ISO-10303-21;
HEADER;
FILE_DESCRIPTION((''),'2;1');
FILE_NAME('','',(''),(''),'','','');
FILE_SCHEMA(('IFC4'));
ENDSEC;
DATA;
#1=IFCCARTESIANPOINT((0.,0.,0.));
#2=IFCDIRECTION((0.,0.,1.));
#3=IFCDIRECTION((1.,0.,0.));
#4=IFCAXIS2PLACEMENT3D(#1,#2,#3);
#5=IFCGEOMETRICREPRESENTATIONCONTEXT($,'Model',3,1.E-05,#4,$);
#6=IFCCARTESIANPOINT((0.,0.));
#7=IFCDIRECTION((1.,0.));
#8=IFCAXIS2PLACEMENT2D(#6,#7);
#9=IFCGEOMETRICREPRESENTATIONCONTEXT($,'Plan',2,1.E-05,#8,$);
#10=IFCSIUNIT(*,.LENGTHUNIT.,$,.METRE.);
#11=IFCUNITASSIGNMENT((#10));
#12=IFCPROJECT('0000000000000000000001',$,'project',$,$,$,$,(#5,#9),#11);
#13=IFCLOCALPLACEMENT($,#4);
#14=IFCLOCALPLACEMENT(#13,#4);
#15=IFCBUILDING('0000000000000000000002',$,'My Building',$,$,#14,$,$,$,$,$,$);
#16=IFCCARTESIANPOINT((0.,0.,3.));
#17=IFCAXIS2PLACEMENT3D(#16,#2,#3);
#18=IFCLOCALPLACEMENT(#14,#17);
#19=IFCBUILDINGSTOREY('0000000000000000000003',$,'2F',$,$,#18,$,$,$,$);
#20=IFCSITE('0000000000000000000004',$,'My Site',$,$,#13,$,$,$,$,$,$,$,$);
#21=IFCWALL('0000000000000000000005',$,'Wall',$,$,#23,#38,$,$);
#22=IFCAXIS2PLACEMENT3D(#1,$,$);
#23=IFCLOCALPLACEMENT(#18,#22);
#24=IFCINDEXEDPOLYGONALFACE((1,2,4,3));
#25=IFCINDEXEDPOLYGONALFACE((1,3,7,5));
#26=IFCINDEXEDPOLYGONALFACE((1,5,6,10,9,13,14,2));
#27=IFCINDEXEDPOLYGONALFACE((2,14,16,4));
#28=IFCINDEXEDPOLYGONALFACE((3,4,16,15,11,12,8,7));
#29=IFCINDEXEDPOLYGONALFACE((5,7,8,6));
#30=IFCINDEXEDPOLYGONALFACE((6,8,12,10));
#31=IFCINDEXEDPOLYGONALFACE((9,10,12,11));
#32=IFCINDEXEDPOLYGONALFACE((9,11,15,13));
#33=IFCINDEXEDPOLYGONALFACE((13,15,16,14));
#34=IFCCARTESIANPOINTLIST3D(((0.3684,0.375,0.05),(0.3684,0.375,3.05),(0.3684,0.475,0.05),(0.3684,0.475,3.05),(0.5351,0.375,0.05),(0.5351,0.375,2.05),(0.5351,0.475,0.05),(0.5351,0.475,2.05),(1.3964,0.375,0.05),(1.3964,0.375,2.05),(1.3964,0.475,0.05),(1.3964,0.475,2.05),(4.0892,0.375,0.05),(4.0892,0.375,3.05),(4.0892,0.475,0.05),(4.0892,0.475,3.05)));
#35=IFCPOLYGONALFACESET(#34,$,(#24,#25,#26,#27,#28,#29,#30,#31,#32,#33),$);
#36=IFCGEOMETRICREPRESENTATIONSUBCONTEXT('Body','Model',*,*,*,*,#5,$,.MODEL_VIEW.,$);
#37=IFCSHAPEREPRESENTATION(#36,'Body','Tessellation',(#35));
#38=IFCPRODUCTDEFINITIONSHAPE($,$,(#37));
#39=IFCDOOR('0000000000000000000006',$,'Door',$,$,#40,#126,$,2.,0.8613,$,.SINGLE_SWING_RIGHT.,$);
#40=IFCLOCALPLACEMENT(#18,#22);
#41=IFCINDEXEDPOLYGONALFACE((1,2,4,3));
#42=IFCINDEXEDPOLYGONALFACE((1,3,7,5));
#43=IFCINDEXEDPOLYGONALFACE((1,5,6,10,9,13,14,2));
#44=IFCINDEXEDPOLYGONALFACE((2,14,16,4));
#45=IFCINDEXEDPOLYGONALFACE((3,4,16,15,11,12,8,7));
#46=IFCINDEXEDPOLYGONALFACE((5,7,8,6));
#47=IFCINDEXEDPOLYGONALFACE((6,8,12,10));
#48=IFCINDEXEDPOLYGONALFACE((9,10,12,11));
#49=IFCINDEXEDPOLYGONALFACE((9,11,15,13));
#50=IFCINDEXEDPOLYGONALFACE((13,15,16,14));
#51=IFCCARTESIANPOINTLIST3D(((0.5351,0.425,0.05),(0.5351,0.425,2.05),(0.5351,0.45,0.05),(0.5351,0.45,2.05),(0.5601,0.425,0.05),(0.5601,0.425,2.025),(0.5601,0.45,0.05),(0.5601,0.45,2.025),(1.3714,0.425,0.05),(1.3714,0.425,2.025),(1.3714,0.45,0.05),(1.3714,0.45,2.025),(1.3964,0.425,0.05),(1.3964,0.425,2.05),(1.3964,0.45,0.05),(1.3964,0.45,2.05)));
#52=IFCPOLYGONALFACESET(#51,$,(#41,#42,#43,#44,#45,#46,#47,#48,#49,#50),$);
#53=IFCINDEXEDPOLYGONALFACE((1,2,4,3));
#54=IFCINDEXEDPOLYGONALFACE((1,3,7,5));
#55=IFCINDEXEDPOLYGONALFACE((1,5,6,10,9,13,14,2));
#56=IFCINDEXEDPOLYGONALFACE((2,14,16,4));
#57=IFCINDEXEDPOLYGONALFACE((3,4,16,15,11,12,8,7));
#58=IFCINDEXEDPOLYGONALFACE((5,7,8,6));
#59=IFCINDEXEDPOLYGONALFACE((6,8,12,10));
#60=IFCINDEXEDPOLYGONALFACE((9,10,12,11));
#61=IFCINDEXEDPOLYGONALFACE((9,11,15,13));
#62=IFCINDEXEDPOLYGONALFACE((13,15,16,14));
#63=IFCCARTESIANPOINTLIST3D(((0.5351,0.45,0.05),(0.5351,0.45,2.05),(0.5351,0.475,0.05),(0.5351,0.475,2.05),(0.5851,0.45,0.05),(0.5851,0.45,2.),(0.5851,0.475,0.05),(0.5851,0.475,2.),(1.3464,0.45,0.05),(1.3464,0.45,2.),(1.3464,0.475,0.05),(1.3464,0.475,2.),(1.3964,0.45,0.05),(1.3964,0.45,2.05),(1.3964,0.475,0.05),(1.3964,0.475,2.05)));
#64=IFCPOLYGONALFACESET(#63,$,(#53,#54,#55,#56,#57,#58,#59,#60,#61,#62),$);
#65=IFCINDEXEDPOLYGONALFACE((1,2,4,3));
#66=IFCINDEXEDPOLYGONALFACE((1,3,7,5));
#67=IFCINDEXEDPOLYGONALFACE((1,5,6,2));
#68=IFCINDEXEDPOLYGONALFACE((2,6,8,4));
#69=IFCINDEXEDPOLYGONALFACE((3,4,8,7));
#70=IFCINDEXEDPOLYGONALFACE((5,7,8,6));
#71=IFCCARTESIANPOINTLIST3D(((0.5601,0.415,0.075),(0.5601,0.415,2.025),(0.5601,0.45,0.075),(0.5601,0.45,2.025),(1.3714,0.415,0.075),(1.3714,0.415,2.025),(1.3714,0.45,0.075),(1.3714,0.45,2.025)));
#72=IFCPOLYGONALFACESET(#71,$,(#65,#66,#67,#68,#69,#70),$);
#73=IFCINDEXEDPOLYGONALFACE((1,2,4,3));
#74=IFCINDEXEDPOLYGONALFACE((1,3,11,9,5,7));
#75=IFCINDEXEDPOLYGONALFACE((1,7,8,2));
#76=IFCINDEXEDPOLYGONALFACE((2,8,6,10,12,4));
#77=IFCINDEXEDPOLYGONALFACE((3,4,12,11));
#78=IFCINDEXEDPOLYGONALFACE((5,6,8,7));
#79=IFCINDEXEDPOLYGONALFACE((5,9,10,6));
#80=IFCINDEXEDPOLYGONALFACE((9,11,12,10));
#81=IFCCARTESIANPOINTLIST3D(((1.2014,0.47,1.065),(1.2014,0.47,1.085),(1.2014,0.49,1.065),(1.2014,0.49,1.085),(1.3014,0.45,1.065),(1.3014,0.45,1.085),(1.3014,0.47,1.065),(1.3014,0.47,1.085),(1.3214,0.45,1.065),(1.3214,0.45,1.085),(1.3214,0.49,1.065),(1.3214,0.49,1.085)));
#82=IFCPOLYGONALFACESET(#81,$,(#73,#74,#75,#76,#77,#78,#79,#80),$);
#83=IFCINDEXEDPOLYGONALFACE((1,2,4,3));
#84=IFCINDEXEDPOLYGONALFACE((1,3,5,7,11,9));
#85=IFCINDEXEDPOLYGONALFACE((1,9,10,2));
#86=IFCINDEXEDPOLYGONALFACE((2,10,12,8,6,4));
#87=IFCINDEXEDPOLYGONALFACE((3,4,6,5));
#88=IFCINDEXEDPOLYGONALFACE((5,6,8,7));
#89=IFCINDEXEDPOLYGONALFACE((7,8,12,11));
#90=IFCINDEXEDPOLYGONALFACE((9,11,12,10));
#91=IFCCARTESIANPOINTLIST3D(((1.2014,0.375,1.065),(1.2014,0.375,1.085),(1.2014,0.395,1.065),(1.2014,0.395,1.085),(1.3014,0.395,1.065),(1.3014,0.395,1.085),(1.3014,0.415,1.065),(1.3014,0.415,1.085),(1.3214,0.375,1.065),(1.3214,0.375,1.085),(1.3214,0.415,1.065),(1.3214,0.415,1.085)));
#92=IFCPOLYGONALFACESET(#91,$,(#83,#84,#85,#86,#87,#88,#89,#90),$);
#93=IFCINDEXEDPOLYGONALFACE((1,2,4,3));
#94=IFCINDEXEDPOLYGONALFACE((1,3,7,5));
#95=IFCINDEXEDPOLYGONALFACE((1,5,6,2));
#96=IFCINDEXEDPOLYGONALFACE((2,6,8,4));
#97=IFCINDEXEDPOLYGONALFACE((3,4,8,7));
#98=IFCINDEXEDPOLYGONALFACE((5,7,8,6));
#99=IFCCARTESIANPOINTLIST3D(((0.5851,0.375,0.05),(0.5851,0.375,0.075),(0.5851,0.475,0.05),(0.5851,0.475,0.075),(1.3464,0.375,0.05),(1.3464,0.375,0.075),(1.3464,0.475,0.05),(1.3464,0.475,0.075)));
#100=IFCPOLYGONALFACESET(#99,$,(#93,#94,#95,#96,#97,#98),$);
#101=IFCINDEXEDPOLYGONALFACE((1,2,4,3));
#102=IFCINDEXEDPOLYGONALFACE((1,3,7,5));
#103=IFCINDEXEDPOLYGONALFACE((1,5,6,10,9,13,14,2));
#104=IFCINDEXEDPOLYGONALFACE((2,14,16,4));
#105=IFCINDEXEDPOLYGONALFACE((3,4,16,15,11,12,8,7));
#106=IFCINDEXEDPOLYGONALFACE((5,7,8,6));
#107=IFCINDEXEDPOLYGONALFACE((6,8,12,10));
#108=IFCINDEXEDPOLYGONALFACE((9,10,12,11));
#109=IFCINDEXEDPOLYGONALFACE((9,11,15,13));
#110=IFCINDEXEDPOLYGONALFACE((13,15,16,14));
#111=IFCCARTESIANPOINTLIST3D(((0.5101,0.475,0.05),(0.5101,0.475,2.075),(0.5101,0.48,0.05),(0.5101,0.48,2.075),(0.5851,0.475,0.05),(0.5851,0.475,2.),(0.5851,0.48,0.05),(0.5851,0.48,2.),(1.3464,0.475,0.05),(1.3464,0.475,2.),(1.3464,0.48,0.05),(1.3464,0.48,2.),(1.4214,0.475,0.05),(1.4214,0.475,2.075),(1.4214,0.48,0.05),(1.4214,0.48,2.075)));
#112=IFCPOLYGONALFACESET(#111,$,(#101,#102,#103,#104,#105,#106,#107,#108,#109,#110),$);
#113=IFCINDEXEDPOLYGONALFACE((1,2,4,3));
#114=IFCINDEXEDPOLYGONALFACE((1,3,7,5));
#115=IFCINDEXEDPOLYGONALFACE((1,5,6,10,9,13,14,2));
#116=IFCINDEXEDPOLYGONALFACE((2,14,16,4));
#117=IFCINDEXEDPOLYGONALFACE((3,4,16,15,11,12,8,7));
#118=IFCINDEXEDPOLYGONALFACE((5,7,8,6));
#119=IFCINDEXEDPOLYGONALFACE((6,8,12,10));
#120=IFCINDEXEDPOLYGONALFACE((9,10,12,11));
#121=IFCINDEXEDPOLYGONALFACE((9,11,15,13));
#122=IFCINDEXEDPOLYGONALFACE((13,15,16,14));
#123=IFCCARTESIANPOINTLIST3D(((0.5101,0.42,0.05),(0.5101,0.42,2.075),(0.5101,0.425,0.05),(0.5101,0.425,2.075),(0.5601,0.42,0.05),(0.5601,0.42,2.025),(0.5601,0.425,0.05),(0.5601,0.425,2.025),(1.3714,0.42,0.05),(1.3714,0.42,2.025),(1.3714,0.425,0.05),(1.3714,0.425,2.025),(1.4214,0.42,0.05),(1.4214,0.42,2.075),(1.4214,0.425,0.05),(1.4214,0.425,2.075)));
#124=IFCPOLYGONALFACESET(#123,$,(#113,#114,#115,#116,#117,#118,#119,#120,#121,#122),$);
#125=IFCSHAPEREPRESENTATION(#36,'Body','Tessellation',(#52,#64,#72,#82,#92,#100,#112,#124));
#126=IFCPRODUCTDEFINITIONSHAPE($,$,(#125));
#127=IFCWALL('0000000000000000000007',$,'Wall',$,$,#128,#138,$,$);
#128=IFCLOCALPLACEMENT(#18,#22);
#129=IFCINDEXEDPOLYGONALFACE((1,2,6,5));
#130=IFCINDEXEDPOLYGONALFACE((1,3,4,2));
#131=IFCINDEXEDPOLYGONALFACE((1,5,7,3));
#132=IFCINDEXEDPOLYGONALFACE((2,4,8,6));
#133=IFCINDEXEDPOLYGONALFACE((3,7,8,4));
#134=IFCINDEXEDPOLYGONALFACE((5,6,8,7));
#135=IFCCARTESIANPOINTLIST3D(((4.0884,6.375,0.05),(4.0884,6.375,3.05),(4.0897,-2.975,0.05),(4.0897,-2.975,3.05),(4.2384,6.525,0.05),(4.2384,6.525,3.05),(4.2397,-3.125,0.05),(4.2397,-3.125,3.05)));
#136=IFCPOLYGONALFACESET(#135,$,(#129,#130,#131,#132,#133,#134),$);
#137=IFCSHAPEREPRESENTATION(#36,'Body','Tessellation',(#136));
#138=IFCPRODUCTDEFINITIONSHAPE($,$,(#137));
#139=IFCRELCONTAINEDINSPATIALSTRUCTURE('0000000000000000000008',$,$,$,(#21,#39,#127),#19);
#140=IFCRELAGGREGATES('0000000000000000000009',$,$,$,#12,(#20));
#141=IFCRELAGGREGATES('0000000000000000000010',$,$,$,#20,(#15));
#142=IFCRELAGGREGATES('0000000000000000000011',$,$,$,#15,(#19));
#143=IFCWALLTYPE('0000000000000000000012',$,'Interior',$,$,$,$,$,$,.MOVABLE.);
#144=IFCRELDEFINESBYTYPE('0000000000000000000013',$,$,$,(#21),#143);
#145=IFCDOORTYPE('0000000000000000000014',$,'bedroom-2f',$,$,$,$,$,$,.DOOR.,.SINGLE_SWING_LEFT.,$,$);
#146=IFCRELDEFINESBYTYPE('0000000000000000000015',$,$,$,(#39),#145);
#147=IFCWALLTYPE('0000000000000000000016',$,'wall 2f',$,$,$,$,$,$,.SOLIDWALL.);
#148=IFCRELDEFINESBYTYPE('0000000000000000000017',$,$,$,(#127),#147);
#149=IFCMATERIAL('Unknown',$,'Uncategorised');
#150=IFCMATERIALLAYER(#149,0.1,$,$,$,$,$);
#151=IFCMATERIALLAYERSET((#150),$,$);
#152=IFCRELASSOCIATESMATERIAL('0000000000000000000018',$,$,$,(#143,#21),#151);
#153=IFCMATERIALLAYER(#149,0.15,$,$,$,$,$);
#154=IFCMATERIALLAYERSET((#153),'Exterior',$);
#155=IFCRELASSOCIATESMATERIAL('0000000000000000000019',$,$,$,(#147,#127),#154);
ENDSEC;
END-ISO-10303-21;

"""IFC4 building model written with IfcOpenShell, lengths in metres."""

from ifc_helpers import new_model, entity, si_unit, frame, origin_with_axes, origin_2d_with_axis, place, context, subcontext, project, spatial, line, indexed_curve, outline, extrude, shape, source, transform, mapped, material, layer, layer_set, layer_usage, type_object, type_shapes, element, fill, save


model = new_model("IFC4")

# Units and contexts
model_context = context("Model", 3, precision=1e-05, world=origin_with_axes())
plan_context = context("Plan", 2, precision=1e-05, world=origin_2d_with_axis())
body_context_1 = subcontext(model_context, "Body", "Model", "MODEL_VIEW")
body_context_2 = subcontext(plan_context, "Body", "Plan", "PLAN_VIEW")
ifc_project = project(units=[si_unit("LENGTHUNIT", "METRE")], contexts=[model_context, plan_context])

# Site, building, storey
site_placement = place(None, origin_with_axes())
site = spatial("IfcSite", under=ifc_project, at=site_placement, Name="My Site")
building_placement = place(site_placement, origin_with_axes())
building = spatial("IfcBuilding", under=site, at=building_placement, Name="My Building")
storey_placement = place(building_placement, frame((0.0, 0.0, 3.0), z_axis=(0.0, 0.0, 1.0), x_axis=(1.0, 0.0, 0.0)))
storey = spatial("IfcBuildingStorey", under=building, at=storey_placement, Name="2F")

# Shared definitions
ifc_material = material(Name="Unknown", Category="Uncategorised")

# Wall, opening, door
ifc_layer_1 = layer(ifc_material, 0.1)
ifc_layer_set_1 = layer_set([ifc_layer_1])
ifc_layer_usage_1 = layer_usage(ifc_layer_set_1, "AXIS2", "POSITIVE", 0.0)
wall_type_1 = type_object("IfcWallType", Name="Interior", PredefinedType="MOVABLE", material=ifc_layer_set_1)
wall_1_placement = place(storey_placement, frame((0.3684, 0.375, 0.05), z_axis=(0.0, 0.0, 1.0), x_axis=(1.0, 0.0, 0.0)))
wall_1 = element("IfcWall", 1, at=wall_1_placement, inside=storey, type_object=wall_type_1, material=ifc_layer_usage_1, Name="Wall", context=body_context_1, shape_type="SweptSolid", body=[
    extrude(outline(indexed_curve([(0.0, 0.0), (0.0, 0.1), (3.7209, 0.1), (3.7209, 0.0)], segments=[line(1, 2, 3, 4, 1)])), origin_with_axes(), (0.0, 0.0, 1.0), 3.0),
])
shared_shape_1 = source(origin_with_axes(), body_context_1, "Body", "SweptSolid", [
    extrude(outline(indexed_curve([(0.0, 0.0), (0.8613, 0.0), (0.8613, 2.0), (0.0, 2.0)], segments=[line(1, 2, 3, 4, 1)])), frame((0.0, -0.6, 0.0), z_axis=(0.0, -1.0, 0.0), x_axis=(1.0, 0.0, 0.0)), (0.0, 0.0, -1.0), 1.2),
])
opening_1_placement = place(wall_1_placement, frame((1.028, 0.1, 0.0), z_axis=(0.0, 0.0, 1.0), x_axis=(-1.0, 0.0, 0.0)))
opening_1 = element("IfcOpeningElement", 2, at=opening_1_placement, cuts=wall_1, PredefinedType="OPENING", context=body_context_1, shape_type="MappedRepresentation", body=[
    mapped(shared_shape_1, transform((0.0, 0.0, 0.0), x_axis=(1.0, 0.0, 0.0), y_axis=(0.0, 1.0, 0.0), z_axis=(0.0, 0.0, 1.0), scale=1.0)),
])
door_type_1 = type_object("IfcDoorType", Name="bedroom-2f", OperationType="SINGLE_SWING_LEFT", PredefinedType="DOOR")
shared_shape_2 = source(origin_with_axes(), body_context_1, "Body", "SweptSolid", [
    extrude(outline(indexed_curve([(0.0, 0.0), (0.0, 2.0), (0.8613, 2.0), (0.8613, 0.0), (0.8363, 0.0), (0.8363, 1.975), (0.025, 1.975), (0.025, 0.0)], segments=[line(1, 2, 3, 4, 5, 6, 7, 8, 1)])), frame((0.0, 0.025, 0.0), z_axis=(0.0, -1.0, 0.0), x_axis=(1.0, 0.0, 0.0)), (0.0, 0.0, -1.0), 0.025),
    extrude(outline(indexed_curve([(0.0, 0.0), (0.0, 2.0), (0.8613, 2.0), (0.8613, 0.0), (0.8113, 0.0), (0.8113, 1.95), (0.05, 1.95), (0.05, 0.0)], segments=[line(1, 2, 3, 4, 5, 6, 7, 8, 1)])), frame((0.0, 0.0, 0.0), z_axis=(0.0, -1.0, 0.0), x_axis=(1.0, 0.0, 0.0)), (0.0, 0.0, -1.0), 0.025),
    extrude(outline(indexed_curve([(0.0, 0.0), (0.8113, 0.0), (0.8113, 0.035), (0.0, 0.035)], segments=[line(1, 2, 3, 4, 1)])), frame((0.025, 0.025, 0.025), z_axis=(0.0, 0.0, 1.0), x_axis=(1.0, 0.0, 0.0)), (0.0, 0.0, 1.0), 1.95),
    extrude(outline(indexed_curve([(0.0, 0.0), (0.0, -0.04), (0.12, -0.04), (0.12, -0.02), (0.02, -0.02), (0.02, 0.0)], segments=[line(1, 2, 3, 4, 5, 6, 1)])), frame((0.075, 0.025, 1.015), z_axis=(0.0, 0.0, 1.0), x_axis=(1.0, 0.0, 0.0)), (0.0, 0.0, 1.0), 0.02),
    extrude(outline(indexed_curve([(0.0, 0.0), (0.0, 0.04), (0.12, 0.04), (0.12, 0.02), (0.02, 0.02), (0.02, 0.0)], segments=[line(1, 2, 3, 4, 5, 6, 1)])), frame((0.075, 0.06, 1.015), z_axis=(0.0, 0.0, 1.0), x_axis=(1.0, 0.0, 0.0)), (0.0, 0.0, 1.0), 0.02),
    extrude(outline(indexed_curve([(0.0, 0.0), (0.7613, 0.0), (0.7613, 0.1), (0.0, 0.1)], segments=[line(1, 2, 3, 4, 1)])), frame((0.05, 0.0, 0.0), z_axis=(0.0, 0.0, 1.0), x_axis=(1.0, 0.0, 0.0)), (0.0, 0.0, 1.0), 0.025),
    extrude(outline(indexed_curve([(0.0, 0.0), (0.0, 2.025), (0.9113, 2.025), (0.9113, 0.0), (0.8363, 0.0), (0.8363, 1.95), (0.075, 1.95), (0.075, 0.0)], segments=[line(1, 2, 3, 4, 5, 6, 7, 8, 1)])), frame((-0.025, -0.005, 0.0), z_axis=(0.0, -1.0, 0.0), x_axis=(1.0, 0.0, 0.0)), (0.0, 0.0, -1.0), 0.005),
    extrude(outline(indexed_curve([(0.0, 0.0), (0.0, 2.025), (0.9113, 2.025), (0.9113, 0.0), (0.8613, 0.0), (0.8613, 1.975), (0.05, 1.975), (0.05, 0.0)], segments=[line(1, 2, 3, 4, 5, 6, 7, 8, 1)])), frame((-0.025, 0.05, 0.0), z_axis=(0.0, -1.0, 0.0), x_axis=(1.0, 0.0, 0.0)), (0.0, 0.0, -1.0), 0.005),
])
shared_shape_3 = source(origin_with_axes(), body_context_2, "Body", "Curve2D", [
    entity("IfcIndexedPolyCurve", entity("IfcCartesianPointList2D", [[0.0, 0.0], [0.0, 0.05], [0.025, 0.05], [0.025, 0.025], [0.05, 0.025], [0.05, 0.0]]), [entity("IfcLineIndex", [1, 2, 3, 4, 5, 6, 1])]),
    entity("IfcIndexedPolyCurve", entity("IfcCartesianPointList2D", [[0.8613, 0.0], [0.8613, 0.05], [0.8363, 0.05], [0.8363, 0.025], [0.8113, 0.025], [0.8113, 0.0]]), [entity("IfcLineIndex", [1, 2, 3, 4, 5, 6, 1])]),
    entity("IfcTrimmedCurve", entity("IfcEllipse", entity("IfcAxis2Placement2D", entity("IfcCartesianPoint", [0.8013, 0.05]), entity("IfcDirection", [1.0, 0.0])), 0.7763, 0.8113), [entity("IfcCartesianPoint", [0.8013, 0.8613])], [entity("IfcCartesianPoint", [0.025, 0.05])], True, "CARTESIAN"),
    entity("IfcIndexedPolyCurve", entity("IfcCartesianPointList2D", [[0.8363, 0.05], [0.8013, 0.05], [0.8013, 0.8613], [0.8363, 0.8613]]), [entity("IfcLineIndex", [1, 2, 3, 4, 1])]),
])
type_shapes(door_type_1, [shared_shape_2, shared_shape_3])
door_1_placement = place(opening_1_placement, origin_with_axes())
door_1 = element("IfcDoor", 3, at=door_1_placement, inside=storey, type_object=door_type_1, Name="Door", OperationType="SINGLE_SWING_RIGHT", OverallHeight=2.0, OverallWidth=0.8613, shapes=[
    shape(body_context_1, "Body", "MappedRepresentation", [mapped(shared_shape_2, transform((0.0, 0.0, 0.0), x_axis=(1.0, 0.0, 0.0), y_axis=(0.0, 1.0, 0.0), z_axis=(0.0, 0.0, 1.0), scale=1.0))]),
    shape(body_context_2, "Body", "MappedRepresentation", [mapped(shared_shape_3, transform((0.0, 0.0, 0.0), x_axis=(1.0, 0.0, 0.0), y_axis=(0.0, 1.0, 0.0), z_axis=(0.0, 0.0, 1.0), scale=1.0))]),
])
fill(opening_1, door_1)

# Wall
ifc_layer_2 = layer(ifc_material, 0.15)
ifc_layer_set_2 = layer_set([ifc_layer_2], Name="Exterior")
ifc_layer_usage_2 = layer_usage(ifc_layer_set_2, "AXIS2", "POSITIVE", 0.0)
wall_type_2 = type_object("IfcWallType", Name="wall 2f", PredefinedType="SOLIDWALL", material=ifc_layer_set_2)
wall_2_placement = place(storey_placement, frame((4.2397, -3.125, 0.05), z_axis=(0.0, 0.0, 1.0), x_axis=(-0.000142, 1.0, 0.0)))
element("IfcWall", 4, at=wall_2_placement, inside=storey, type_object=wall_type_2, material=ifc_layer_usage_2, Name="Wall", context=body_context_1, shape_type="SweptSolid", body=[
    extrude(outline(indexed_curve([(0.0, 0.0), (0.15, 0.15), (9.5, 0.15), (9.65, 0.0)], segments=[line(1, 2, 3, 4, 1)])), origin_with_axes(), (0.0, 0.0, 1.0), 3.0),
])

save(model, "model.ifc")
